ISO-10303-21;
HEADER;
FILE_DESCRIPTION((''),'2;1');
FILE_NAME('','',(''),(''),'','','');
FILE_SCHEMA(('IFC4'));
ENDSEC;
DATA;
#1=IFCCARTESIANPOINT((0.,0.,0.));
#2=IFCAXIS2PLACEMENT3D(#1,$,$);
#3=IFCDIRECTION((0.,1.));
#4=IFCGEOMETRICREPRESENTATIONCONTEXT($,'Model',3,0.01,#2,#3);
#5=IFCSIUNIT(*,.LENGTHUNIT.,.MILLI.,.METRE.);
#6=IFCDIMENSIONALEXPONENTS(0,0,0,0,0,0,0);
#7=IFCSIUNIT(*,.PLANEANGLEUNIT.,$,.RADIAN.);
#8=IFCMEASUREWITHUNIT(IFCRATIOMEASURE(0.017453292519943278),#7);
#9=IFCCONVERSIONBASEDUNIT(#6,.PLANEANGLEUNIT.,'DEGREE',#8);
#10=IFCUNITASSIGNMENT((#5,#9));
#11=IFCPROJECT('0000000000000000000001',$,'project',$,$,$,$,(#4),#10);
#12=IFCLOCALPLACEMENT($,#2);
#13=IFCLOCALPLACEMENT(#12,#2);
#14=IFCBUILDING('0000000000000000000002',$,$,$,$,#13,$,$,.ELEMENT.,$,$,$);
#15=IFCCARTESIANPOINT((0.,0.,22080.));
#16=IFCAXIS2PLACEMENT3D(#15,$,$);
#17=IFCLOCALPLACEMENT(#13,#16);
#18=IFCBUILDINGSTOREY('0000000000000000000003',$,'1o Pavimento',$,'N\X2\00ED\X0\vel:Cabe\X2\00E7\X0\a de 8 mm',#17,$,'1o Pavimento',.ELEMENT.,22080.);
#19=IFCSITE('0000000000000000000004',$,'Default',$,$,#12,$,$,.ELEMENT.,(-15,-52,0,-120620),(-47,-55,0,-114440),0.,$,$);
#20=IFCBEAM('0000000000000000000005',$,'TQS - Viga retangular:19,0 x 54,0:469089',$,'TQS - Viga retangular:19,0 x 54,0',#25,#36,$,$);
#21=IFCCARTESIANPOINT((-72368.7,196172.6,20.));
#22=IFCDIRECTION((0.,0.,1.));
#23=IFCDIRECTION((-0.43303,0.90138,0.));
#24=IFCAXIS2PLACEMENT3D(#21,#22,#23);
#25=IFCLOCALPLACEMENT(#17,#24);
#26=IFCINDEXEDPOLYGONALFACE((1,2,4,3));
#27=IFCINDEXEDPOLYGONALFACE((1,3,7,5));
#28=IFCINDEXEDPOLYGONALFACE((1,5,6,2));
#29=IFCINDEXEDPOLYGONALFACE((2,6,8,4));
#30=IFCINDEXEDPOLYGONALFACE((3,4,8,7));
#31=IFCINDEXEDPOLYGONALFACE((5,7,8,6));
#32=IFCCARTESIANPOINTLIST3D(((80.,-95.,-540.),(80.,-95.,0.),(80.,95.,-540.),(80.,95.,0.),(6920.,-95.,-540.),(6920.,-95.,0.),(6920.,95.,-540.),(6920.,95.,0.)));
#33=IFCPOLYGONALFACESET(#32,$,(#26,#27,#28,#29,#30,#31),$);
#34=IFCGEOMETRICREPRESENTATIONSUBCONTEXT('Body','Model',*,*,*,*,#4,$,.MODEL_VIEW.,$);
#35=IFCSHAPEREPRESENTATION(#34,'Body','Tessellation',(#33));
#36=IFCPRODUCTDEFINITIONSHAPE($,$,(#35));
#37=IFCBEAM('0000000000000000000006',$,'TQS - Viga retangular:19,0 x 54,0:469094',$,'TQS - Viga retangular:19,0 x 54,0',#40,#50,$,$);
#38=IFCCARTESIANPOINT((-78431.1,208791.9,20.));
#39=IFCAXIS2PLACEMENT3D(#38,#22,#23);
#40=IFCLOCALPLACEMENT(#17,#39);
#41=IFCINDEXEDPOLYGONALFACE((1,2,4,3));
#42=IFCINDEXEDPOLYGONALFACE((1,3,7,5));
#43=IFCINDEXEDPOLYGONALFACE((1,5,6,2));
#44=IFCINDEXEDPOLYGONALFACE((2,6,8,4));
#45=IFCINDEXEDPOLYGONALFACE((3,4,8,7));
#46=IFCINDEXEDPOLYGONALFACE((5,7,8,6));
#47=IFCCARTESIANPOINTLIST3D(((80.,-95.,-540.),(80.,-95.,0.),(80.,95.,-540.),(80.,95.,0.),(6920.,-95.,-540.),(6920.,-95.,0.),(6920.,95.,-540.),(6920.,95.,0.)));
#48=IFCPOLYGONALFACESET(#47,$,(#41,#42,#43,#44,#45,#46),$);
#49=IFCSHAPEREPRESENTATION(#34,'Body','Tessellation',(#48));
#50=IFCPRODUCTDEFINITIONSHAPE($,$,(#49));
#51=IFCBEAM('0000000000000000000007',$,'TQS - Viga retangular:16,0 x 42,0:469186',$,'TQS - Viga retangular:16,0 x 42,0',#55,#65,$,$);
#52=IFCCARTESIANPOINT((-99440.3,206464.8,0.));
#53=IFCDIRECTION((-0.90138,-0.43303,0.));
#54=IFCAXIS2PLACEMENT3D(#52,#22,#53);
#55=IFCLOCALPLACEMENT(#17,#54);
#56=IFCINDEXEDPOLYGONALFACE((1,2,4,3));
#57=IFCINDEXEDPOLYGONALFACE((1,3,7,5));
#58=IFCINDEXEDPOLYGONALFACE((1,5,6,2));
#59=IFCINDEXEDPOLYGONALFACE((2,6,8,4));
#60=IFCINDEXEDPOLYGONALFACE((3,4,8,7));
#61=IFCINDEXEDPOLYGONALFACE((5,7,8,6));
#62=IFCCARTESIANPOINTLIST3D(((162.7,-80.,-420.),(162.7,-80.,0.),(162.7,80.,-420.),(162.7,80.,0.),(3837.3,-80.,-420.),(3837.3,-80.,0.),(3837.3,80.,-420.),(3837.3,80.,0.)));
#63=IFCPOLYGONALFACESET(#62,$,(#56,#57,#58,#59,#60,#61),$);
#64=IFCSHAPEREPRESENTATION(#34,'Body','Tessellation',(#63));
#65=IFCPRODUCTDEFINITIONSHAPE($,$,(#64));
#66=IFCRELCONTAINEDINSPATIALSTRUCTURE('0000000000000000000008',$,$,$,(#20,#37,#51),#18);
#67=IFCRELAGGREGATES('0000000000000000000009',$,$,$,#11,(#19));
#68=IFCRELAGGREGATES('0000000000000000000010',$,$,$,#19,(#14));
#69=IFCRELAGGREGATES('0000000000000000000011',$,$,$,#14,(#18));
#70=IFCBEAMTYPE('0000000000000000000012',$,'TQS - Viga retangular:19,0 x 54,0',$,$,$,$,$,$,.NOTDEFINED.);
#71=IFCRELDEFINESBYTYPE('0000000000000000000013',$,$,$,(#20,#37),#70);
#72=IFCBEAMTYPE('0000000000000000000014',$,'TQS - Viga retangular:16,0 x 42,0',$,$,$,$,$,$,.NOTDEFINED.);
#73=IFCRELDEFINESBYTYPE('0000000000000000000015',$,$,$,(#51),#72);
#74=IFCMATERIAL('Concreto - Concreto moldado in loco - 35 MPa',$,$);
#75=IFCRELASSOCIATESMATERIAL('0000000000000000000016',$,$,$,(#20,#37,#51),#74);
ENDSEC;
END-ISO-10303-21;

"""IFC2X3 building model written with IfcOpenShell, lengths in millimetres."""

from ifc_helpers import new_model, entity, si_unit, converted_unit, direction, frame, frame_2d, origin, place, context, subcontext, project, spatial, rectangle, extrude, material, type_object, element, save


model = new_model("IFC2X3")

# Units and contexts
model_context = context("Model", 3, precision=0.01, world=origin(), true_north=direction((0.0, 1.0)))
body_context = subcontext(model_context, "Body", "Model", "MODEL_VIEW")
ifc_project = project(units=[si_unit("LENGTHUNIT", "METRE", prefix="MILLI"), converted_unit("PLANEANGLEUNIT", "DEGREE", entity("IfcRatioMeasure", 0.017453292519943278), si_unit("PLANEANGLEUNIT", "RADIAN"), dimensions=[0, 0, 0, 0, 0, 0, 0])], contexts=[model_context])

# Site, building, storey
site_placement = place(None, origin())
site = spatial("IfcSite", under=ifc_project, at=site_placement, Name="Default", CompositionType="ELEMENT", RefLatitude=(-15, -52, 0, -120620), RefLongitude=(-47, -55, 0, -114440), RefElevation=0.0)
building_placement = place(site_placement, origin())
building = spatial("IfcBuilding", under=site, at=building_placement, CompositionType="ELEMENT")
storey_placement = place(building_placement, frame((0.0, 0.0, 22080.0)))
storey = spatial("IfcBuildingStorey", under=building, at=storey_placement, Name="1o Pavimento", ObjectType="Nível:Cabeça de 8 mm", LongName="1o Pavimento", CompositionType="ELEMENT", Elevation=22080.0)

# Beams
ifc_material_1 = material(Name="Concreto - Concreto moldado in loco - 35 MPa")
beam_type_1 = type_object("IfcBeamType", Name="TQS - Viga retangular:19,0 x 54,0", PredefinedType="NOTDEFINED")
beam_1_placement = place(storey_placement, frame((-72368.7, 196172.6, 20.0), z_axis=(0.0, 0.0, 1.0), x_axis=(-0.43303, 0.90138, 0.0)))
element("IfcBeam", 1, at=beam_1_placement, inside=storey, type_object=beam_type_1, material=ifc_material_1, Name="TQS - Viga retangular:19,0 x 54,0:469089", ObjectType="TQS - Viga retangular:19,0 x 54,0", context=body_context, shape_type="SweptSolid", body=[
    extrude(rectangle(XDim=540.0, YDim=190.0, at=frame_2d((0.0, 0.0), x_axis=(1.0, 0.0))), frame((80.0, 0.0, -270.0), z_axis=(1.0, 0.0, 0.0), x_axis=(0.0, 0.0, -1.0)), (0.0, 0.0, 1.0), 6840.0),
])
beam_2_placement = place(storey_placement, frame((-78431.1, 208791.9, 20.0), z_axis=(0.0, 0.0, 1.0), x_axis=(-0.43303, 0.90138, 0.0)))
element("IfcBeam", 2, at=beam_2_placement, inside=storey, type_object=beam_type_1, material=ifc_material_1, Name="TQS - Viga retangular:19,0 x 54,0:469094", ObjectType="TQS - Viga retangular:19,0 x 54,0", context=body_context, shape_type="SweptSolid", body=[
    extrude(rectangle(XDim=540.0, YDim=190.0, at=frame_2d((0.0, 0.0), x_axis=(1.0, 0.0))), frame((80.0, 0.0, -270.0), z_axis=(1.0, 0.0, 0.0), x_axis=(0.0, 0.0, -1.0)), (0.0, 0.0, 1.0), 6840.0),
])
beam_type_2 = type_object("IfcBeamType", Name="TQS - Viga retangular:16,0 x 42,0", PredefinedType="NOTDEFINED")
beam_3_placement = place(storey_placement, frame((-99440.3, 206464.8, 0.0), z_axis=(0.0, 0.0, 1.0), x_axis=(-0.90138, -0.43303, 0.0)))
element("IfcBeam", 3, at=beam_3_placement, inside=storey, type_object=beam_type_2, material=ifc_material_1, Name="TQS - Viga retangular:16,0 x 42,0:469186", ObjectType="TQS - Viga retangular:16,0 x 42,0", context=body_context, shape_type="SweptSolid", body=[
    extrude(rectangle(XDim=420.0, YDim=160.0, at=frame_2d((0.0, 0.0), x_axis=(1.0, 0.0))), frame((162.7, 0.0, -210.0), z_axis=(1.0, 0.0, 0.0), x_axis=(0.0, 0.0, -1.0)), (0.0, 0.0, 1.0), 3674.6),
])

save(model, "model.ifc")
